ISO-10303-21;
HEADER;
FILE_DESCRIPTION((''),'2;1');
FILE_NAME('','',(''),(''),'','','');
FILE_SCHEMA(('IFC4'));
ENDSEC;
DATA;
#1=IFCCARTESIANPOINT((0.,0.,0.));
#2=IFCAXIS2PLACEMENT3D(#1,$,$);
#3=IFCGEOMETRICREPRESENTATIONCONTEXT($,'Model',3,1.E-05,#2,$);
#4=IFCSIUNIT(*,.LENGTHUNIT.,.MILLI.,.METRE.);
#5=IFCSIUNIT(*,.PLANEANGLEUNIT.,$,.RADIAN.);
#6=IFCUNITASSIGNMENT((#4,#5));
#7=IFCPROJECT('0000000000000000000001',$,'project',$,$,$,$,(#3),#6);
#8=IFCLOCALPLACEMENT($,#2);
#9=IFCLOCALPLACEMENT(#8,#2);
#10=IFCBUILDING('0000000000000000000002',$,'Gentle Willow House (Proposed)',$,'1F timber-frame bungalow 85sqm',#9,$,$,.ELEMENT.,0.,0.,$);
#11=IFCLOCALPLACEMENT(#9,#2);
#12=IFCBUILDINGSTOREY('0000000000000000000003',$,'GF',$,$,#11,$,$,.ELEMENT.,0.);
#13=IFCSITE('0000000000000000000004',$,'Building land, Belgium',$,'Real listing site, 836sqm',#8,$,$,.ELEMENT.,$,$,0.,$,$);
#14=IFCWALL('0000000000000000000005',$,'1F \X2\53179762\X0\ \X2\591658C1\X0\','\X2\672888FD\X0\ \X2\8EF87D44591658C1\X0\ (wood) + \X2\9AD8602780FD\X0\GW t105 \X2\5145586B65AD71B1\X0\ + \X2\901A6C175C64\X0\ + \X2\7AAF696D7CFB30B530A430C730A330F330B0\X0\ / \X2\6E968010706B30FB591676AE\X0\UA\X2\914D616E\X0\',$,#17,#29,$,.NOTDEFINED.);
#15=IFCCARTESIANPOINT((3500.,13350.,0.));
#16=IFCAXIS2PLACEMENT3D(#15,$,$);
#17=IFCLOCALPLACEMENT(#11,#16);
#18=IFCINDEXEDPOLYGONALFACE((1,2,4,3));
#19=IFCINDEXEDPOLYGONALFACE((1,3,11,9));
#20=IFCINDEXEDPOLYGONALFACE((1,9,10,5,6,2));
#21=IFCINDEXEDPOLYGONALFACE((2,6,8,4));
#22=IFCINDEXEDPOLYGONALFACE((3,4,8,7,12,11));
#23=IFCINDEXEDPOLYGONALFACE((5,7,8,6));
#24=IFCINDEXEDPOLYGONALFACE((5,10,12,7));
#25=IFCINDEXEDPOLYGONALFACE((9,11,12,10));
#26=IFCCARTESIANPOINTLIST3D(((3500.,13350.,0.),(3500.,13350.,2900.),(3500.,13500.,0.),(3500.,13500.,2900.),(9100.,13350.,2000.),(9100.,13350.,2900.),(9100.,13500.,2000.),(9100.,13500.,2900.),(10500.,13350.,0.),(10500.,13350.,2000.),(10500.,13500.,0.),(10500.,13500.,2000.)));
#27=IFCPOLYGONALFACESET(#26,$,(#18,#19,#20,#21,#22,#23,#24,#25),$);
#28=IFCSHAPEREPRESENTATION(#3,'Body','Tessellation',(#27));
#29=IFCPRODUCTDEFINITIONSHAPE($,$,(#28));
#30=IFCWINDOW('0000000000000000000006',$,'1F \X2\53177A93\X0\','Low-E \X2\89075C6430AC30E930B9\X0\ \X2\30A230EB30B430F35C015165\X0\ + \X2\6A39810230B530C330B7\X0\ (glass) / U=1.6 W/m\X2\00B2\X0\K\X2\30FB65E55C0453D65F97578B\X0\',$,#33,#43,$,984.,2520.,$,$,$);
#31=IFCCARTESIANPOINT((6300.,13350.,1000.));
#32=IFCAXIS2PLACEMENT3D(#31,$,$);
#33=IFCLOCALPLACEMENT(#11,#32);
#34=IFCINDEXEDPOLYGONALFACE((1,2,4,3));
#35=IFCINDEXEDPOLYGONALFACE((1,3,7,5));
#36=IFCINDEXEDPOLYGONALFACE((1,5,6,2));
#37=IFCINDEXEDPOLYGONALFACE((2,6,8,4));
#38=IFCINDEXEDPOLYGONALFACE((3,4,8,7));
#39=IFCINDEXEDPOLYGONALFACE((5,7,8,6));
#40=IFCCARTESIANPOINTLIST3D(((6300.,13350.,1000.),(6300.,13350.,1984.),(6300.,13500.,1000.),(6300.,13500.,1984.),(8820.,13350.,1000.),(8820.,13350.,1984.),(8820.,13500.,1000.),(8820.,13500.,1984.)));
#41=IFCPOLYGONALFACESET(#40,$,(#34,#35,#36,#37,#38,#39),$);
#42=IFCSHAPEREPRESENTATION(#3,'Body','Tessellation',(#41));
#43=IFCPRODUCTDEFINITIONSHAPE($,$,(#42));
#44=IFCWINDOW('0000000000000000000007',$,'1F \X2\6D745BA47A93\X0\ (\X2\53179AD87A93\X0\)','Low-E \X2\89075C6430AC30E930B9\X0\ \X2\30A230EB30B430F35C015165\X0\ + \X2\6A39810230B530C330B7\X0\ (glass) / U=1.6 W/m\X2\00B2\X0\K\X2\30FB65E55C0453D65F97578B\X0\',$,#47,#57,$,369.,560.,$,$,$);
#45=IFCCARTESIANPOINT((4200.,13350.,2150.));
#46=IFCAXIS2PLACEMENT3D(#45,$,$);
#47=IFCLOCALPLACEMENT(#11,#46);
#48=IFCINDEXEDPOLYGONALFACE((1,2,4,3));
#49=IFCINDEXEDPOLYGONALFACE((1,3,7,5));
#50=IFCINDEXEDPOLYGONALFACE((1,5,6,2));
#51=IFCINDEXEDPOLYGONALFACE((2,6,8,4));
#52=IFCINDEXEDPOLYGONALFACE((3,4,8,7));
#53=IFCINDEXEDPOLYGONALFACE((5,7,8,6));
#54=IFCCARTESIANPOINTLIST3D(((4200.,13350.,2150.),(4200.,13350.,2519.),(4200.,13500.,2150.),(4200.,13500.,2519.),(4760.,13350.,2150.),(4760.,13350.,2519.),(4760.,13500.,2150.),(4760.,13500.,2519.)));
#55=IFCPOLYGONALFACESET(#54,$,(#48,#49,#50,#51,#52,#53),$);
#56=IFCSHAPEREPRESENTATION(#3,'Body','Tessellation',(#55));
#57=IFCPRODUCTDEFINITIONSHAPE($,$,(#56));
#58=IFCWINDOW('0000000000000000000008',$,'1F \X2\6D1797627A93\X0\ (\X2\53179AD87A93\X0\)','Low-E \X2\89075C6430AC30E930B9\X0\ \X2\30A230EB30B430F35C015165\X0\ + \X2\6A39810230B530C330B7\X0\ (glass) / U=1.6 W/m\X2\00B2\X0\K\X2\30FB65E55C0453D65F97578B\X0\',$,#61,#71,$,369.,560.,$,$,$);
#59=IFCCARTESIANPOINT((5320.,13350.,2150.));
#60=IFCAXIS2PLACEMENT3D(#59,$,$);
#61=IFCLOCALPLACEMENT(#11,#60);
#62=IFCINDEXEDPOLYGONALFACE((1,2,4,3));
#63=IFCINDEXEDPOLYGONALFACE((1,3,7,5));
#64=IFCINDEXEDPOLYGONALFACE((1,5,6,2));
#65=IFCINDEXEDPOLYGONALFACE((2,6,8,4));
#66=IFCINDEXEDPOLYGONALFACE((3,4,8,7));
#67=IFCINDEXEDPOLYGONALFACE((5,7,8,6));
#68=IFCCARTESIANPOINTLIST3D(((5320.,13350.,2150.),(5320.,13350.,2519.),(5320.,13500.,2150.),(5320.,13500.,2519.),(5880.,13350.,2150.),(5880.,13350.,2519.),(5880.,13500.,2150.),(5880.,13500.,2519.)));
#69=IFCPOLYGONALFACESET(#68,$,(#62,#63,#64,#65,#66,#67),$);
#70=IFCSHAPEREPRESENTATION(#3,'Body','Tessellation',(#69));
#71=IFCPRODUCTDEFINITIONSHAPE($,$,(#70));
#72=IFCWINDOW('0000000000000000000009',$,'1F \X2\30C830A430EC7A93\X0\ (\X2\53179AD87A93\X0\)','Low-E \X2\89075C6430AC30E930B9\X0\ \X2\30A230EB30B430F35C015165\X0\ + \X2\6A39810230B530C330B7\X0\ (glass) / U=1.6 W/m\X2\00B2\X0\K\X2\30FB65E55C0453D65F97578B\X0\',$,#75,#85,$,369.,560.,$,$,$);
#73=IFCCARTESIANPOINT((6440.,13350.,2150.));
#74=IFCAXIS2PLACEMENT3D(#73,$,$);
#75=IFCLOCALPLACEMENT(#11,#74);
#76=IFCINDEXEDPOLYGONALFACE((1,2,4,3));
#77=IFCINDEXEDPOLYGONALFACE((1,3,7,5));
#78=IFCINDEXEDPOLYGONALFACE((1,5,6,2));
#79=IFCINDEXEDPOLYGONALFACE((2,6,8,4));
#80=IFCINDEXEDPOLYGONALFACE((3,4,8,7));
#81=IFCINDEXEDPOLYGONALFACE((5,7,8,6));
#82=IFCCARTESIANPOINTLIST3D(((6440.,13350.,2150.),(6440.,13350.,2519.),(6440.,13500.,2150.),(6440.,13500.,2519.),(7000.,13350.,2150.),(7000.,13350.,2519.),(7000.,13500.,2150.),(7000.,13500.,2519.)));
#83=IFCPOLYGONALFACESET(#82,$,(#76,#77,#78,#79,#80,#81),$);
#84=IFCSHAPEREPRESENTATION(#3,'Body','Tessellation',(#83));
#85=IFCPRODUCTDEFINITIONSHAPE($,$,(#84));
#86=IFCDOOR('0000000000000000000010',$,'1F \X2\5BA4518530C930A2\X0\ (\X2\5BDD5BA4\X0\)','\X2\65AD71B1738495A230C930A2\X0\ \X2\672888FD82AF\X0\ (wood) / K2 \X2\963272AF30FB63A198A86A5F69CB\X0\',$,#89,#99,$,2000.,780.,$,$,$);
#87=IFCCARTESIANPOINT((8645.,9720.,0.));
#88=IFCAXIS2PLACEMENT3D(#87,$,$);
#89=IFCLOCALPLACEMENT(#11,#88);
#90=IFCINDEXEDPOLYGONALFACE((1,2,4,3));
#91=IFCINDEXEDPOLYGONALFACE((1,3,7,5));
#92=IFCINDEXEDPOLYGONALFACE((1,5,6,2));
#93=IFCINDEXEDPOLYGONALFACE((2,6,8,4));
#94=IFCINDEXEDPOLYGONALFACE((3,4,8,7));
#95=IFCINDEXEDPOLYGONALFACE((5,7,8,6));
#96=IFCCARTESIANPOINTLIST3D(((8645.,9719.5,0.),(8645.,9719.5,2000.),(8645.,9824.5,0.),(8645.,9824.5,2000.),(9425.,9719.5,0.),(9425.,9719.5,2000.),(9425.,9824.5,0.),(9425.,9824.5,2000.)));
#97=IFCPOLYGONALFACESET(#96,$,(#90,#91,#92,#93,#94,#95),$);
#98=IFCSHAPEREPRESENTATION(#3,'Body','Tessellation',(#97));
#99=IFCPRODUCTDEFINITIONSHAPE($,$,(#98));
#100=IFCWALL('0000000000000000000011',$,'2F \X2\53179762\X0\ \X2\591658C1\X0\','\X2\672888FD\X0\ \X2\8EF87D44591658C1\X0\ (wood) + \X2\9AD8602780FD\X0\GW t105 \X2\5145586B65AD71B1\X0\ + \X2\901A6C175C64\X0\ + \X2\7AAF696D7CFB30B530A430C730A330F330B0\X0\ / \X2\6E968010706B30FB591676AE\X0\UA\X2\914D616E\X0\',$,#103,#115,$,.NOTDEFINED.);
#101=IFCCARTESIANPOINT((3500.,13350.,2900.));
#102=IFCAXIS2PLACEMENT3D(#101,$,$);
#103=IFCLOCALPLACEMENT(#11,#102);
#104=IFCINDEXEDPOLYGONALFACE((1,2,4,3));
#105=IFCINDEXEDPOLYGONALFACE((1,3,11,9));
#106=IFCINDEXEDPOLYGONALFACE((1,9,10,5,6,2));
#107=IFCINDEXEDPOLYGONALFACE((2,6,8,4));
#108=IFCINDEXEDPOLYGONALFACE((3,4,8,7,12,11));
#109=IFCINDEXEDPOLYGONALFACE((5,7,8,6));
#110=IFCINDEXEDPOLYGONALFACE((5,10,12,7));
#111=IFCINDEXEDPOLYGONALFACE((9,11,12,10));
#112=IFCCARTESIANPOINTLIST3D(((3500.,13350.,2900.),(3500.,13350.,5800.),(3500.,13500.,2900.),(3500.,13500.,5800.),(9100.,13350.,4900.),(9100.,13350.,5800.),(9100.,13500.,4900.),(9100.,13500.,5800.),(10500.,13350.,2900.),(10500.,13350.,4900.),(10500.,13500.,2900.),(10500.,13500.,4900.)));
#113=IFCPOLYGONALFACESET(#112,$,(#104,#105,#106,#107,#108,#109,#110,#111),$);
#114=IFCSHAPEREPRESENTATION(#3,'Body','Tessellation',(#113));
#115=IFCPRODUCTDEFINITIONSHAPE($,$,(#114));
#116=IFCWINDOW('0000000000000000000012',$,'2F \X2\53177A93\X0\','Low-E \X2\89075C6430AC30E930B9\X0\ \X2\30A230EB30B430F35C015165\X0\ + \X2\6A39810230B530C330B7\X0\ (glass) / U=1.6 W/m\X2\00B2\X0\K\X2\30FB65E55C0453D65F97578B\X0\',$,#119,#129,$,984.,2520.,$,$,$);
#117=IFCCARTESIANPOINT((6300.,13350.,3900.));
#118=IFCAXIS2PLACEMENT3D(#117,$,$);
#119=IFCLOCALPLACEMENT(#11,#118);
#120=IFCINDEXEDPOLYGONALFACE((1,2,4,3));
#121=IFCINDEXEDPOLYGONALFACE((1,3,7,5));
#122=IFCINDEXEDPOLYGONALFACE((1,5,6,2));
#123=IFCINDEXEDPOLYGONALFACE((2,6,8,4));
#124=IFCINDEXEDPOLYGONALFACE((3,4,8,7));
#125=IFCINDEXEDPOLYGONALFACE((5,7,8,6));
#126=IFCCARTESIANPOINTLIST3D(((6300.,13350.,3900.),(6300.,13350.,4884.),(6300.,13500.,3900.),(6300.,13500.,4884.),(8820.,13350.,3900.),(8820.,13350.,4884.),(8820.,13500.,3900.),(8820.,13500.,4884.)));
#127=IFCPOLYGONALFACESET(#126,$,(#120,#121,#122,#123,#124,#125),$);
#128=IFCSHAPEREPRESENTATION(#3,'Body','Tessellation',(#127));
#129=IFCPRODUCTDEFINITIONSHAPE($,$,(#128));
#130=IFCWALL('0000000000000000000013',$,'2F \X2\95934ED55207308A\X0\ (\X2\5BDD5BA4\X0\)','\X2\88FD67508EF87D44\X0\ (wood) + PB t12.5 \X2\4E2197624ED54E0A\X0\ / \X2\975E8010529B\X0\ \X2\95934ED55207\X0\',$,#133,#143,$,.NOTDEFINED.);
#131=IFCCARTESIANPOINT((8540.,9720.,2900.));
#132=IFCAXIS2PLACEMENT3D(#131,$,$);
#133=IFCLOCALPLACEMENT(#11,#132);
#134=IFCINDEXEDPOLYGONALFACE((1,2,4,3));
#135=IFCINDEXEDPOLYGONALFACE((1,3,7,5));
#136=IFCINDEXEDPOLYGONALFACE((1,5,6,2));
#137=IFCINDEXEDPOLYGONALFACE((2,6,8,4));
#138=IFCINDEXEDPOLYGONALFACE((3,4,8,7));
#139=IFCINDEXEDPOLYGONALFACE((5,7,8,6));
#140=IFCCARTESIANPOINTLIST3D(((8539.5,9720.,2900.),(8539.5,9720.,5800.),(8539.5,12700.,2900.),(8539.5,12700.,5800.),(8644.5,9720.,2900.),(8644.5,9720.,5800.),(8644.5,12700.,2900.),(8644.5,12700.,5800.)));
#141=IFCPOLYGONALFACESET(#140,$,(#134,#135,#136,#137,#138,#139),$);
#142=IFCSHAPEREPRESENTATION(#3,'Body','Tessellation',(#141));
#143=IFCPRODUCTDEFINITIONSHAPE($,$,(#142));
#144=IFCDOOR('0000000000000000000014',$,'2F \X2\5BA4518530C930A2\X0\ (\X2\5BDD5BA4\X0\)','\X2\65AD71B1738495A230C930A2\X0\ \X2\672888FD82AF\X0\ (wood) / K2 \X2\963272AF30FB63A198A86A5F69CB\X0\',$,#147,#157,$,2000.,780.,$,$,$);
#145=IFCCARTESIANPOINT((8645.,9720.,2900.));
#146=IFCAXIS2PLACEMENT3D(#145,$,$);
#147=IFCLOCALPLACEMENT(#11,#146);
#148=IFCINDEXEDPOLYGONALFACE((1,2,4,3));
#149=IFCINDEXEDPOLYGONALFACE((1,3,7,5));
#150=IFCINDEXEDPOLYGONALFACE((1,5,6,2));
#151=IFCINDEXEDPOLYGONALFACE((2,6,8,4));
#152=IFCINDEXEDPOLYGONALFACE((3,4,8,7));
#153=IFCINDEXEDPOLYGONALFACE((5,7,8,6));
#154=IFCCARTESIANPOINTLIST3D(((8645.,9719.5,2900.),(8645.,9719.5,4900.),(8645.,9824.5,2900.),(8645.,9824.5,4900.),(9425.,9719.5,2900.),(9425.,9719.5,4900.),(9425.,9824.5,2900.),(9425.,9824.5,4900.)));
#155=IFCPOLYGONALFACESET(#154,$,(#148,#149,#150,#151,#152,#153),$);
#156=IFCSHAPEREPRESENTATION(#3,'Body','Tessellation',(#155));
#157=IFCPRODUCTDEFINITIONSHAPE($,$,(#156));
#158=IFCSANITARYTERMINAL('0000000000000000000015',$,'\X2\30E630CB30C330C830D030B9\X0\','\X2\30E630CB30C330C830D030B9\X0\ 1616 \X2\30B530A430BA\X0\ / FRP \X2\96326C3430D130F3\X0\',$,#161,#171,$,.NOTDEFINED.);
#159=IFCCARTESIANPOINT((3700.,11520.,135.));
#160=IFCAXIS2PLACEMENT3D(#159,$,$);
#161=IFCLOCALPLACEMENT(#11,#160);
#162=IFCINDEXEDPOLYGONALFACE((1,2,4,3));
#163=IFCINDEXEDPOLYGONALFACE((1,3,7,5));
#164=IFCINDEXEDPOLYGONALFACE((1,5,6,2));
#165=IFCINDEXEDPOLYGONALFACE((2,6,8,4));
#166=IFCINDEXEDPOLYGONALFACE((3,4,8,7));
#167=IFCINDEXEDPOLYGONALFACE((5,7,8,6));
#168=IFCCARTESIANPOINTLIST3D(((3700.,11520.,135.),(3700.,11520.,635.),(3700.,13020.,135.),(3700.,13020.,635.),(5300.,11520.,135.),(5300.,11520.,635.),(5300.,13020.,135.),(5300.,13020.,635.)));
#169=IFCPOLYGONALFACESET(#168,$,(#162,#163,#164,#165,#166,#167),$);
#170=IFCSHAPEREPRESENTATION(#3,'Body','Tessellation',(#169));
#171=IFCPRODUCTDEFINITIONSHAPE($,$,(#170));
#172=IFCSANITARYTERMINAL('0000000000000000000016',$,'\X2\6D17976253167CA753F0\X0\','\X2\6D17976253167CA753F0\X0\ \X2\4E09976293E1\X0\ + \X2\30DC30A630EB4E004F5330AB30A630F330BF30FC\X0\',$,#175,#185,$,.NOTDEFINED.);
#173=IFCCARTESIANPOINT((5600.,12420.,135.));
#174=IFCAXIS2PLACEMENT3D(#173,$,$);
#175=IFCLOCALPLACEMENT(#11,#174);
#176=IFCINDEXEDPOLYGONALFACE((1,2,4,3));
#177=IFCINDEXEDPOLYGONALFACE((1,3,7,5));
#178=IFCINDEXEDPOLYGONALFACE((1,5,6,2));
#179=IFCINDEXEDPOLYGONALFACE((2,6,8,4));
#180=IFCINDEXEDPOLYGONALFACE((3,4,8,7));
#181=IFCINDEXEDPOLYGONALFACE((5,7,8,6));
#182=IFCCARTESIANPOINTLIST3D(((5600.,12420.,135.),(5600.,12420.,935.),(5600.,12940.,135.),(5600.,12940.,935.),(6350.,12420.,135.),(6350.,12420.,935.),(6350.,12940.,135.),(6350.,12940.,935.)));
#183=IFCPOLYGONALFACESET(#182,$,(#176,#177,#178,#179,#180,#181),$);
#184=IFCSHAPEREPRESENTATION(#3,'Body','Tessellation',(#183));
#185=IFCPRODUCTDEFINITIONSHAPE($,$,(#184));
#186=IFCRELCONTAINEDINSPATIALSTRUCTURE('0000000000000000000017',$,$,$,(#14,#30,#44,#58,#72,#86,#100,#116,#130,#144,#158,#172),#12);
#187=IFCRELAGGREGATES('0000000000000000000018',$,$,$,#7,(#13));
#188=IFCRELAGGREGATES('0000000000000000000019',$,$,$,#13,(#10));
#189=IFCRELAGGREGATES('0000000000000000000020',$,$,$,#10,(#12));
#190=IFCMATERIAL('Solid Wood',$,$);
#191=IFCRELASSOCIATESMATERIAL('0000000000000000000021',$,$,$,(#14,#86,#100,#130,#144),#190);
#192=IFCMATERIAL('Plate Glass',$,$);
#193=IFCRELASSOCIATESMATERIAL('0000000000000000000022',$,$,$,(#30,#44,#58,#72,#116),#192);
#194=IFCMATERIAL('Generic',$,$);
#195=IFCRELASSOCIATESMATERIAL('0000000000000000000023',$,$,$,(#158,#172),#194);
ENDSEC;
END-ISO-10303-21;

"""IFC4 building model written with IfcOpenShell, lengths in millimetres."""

from ifc_helpers import new_model, si_unit, frame, frame_2d, origin, place, context, project, spatial, rectangle, extrude, material, element, fill, save


model = new_model("IFC4")

# Units and contexts
model_context = context("Model", 3, precision=1e-05, world=origin())
ifc_project = project(units=[si_unit("LENGTHUNIT", "METRE", prefix="MILLI"), si_unit("PLANEANGLEUNIT", "RADIAN")], contexts=[model_context])

# Site, building, storey
site_placement = place(None, origin())
site = spatial("IfcSite", under=ifc_project, at=site_placement, Name="Building land, Belgium", ObjectType="Real listing site, 836sqm", CompositionType="ELEMENT", RefElevation=0.0)
building_placement = place(site_placement, origin())
building = spatial("IfcBuilding", under=site, at=building_placement, Name="Gentle Willow House (Proposed)", ObjectType="1F timber-frame bungalow 85sqm", CompositionType="ELEMENT", ElevationOfRefHeight=0.0, ElevationOfTerrain=0.0)
storey_placement = place(building_placement, origin())
storey = spatial("IfcBuildingStorey", under=building, at=storey_placement, Name="GF", CompositionType="ELEMENT", Elevation=0.0)

# Wall, openings, windows
ifc_material_1 = material(Name="Solid Wood")
wall_1_placement = place(storey_placement, frame((3500.0, 13350.0, 0.0)))
wall_1 = element("IfcWall", 1, at=wall_1_placement, inside=storey, material=ifc_material_1, Name="1F 北面 外壁", Description="木製 軸組外壁 (wood) + 高性能GW t105 充填断熱 + 通気層 + 窯業系サイディング / 準耐火・外皮UA配慮", PredefinedType="NOTDEFINED", context=model_context, shape_type="SweptSolid", body=[
    extrude(rectangle(XDim=7000.0, YDim=150.0, at=frame_2d((3500.0, 75.0))), frame((3500.0, 13350.0, 0.0)), (0.0, 0.0, 1.0), 2900.0),
])
opening_1_placement = place(storey_placement, frame((6300.0, 13350.0, 1000.0)))
opening_1 = element("IfcOpeningElement", 2, at=opening_1_placement, cuts=wall_1, PredefinedType="NOTDEFINED", context=model_context, shape_type="SweptSolid", body=[
    extrude(rectangle(XDim=2520.0, YDim=150.0, at=frame_2d((1260.0, 75.0))), frame((6300.0, 13350.0, 1000.0)), (0.0, 0.0, 1.0), 984.0),
])
opening_2_placement = place(storey_placement, frame((4200.0, 13350.0, 2150.0)))
opening_2 = element("IfcOpeningElement", 3, at=opening_2_placement, cuts=wall_1, PredefinedType="NOTDEFINED", context=model_context, shape_type="SweptSolid", body=[
    extrude(rectangle(XDim=560.0, YDim=150.0, at=frame_2d((280.0, 75.0))), frame((4200.0, 13350.0, 2150.0)), (0.0, 0.0, 1.0), 369.0),
])
opening_3_placement = place(storey_placement, frame((5320.0, 13350.0, 2150.0)))
opening_3 = element("IfcOpeningElement", 4, at=opening_3_placement, cuts=wall_1, PredefinedType="NOTDEFINED", context=model_context, shape_type="SweptSolid", body=[
    extrude(rectangle(XDim=560.0, YDim=150.0, at=frame_2d((280.0, 75.0))), frame((5320.0, 13350.0, 2150.0)), (0.0, 0.0, 1.0), 369.0),
])
opening_4_placement = place(storey_placement, frame((6440.0, 13350.0, 2150.0)))
opening_4 = element("IfcOpeningElement", 5, at=opening_4_placement, cuts=wall_1, PredefinedType="NOTDEFINED", context=model_context, shape_type="SweptSolid", body=[
    extrude(rectangle(XDim=560.0, YDim=150.0, at=frame_2d((280.0, 75.0))), frame((6440.0, 13350.0, 2150.0)), (0.0, 0.0, 1.0), 369.0),
])
ifc_material_2 = material(Name="Plate Glass")
window_1_placement = place(storey_placement, frame((6300.0, 13350.0, 1000.0)))
window_1 = element("IfcWindow", 6, at=window_1_placement, inside=storey, material=ifc_material_2, Name="1F 北窓", Description="Low-E 複層ガラス アルゴン封入 + 樹脂サッシ (glass) / U=1.6 W/m²K・日射取得型", OverallHeight=984.0, OverallWidth=2520.0, context=model_context, shape_type="SweptSolid", body=[
    extrude(rectangle(XDim=2520.0, YDim=150.0, at=frame_2d((1260.0, 75.0))), frame((6300.0, 13350.0, 1000.0)), (0.0, 0.0, 1.0), 984.0),
])
fill(opening_1, window_1)
window_2_placement = place(storey_placement, frame((4200.0, 13350.0, 2150.0)))
window_2 = element("IfcWindow", 7, at=window_2_placement, inside=storey, material=ifc_material_2, Name="1F 浴室窓 (北高窓)", Description="Low-E 複層ガラス アルゴン封入 + 樹脂サッシ (glass) / U=1.6 W/m²K・日射取得型", OverallHeight=369.0, OverallWidth=560.0, context=model_context, shape_type="SweptSolid", body=[
    extrude(rectangle(XDim=560.0, YDim=150.0, at=frame_2d((280.0, 75.0))), frame((4200.0, 13350.0, 2150.0)), (0.0, 0.0, 1.0), 369.0),
])
fill(opening_2, window_2)
window_3_placement = place(storey_placement, frame((5320.0, 13350.0, 2150.0)))
window_3 = element("IfcWindow", 8, at=window_3_placement, inside=storey, material=ifc_material_2, Name="1F 洗面窓 (北高窓)", Description="Low-E 複層ガラス アルゴン封入 + 樹脂サッシ (glass) / U=1.6 W/m²K・日射取得型", OverallHeight=369.0, OverallWidth=560.0, context=model_context, shape_type="SweptSolid", body=[
    extrude(rectangle(XDim=560.0, YDim=150.0, at=frame_2d((280.0, 75.0))), frame((5320.0, 13350.0, 2150.0)), (0.0, 0.0, 1.0), 369.0),
])
fill(opening_3, window_3)
window_4_placement = place(storey_placement, frame((6440.0, 13350.0, 2150.0)))
window_4 = element("IfcWindow", 9, at=window_4_placement, inside=storey, material=ifc_material_2, Name="1F トイレ窓 (北高窓)", Description="Low-E 複層ガラス アルゴン封入 + 樹脂サッシ (glass) / U=1.6 W/m²K・日射取得型", OverallHeight=369.0, OverallWidth=560.0, context=model_context, shape_type="SweptSolid", body=[
    extrude(rectangle(XDim=560.0, YDim=150.0, at=frame_2d((280.0, 75.0))), frame((6440.0, 13350.0, 2150.0)), (0.0, 0.0, 1.0), 369.0),
])
fill(opening_4, window_4)

# Door
door_1_placement = place(storey_placement, frame((8645.0, 9720.0, 0.0)))
element("IfcDoor", 10, at=door_1_placement, inside=storey, material=ifc_material_1, Name="1F 室内ドア (寝室)", Description="断熱玄関ドア 木製芯 (wood) / K2 防犯・採風機構", OverallHeight=2000.0, OverallWidth=780.0, context=model_context, shape_type="SweptSolid", body=[
    extrude(rectangle(XDim=780.0, YDim=105.0, at=frame_2d((390.0, 52.0))), frame((8645.0, 9720.0, 0.0)), (0.0, 0.0, 1.0), 2000.0),
])

# Wall, opening, window
wall_2_placement = place(storey_placement, frame((3500.0, 13350.0, 2900.0)))
wall_2 = element("IfcWall", 11, at=wall_2_placement, inside=storey, material=ifc_material_1, Name="2F 北面 外壁", Description="木製 軸組外壁 (wood) + 高性能GW t105 充填断熱 + 通気層 + 窯業系サイディング / 準耐火・外皮UA配慮", PredefinedType="NOTDEFINED", context=model_context, shape_type="SweptSolid", body=[
    extrude(rectangle(XDim=7000.0, YDim=150.0, at=frame_2d((3500.0, 75.0))), frame((3500.0, 13350.0, 2900.0)), (0.0, 0.0, 1.0), 2900.0),
])
opening_5_placement = place(storey_placement, frame((6300.0, 13350.0, 3900.0)))
opening_5 = element("IfcOpeningElement", 12, at=opening_5_placement, cuts=wall_2, PredefinedType="NOTDEFINED", context=model_context, shape_type="SweptSolid", body=[
    extrude(rectangle(XDim=2520.0, YDim=150.0, at=frame_2d((1260.0, 75.0))), frame((6300.0, 13350.0, 3900.0)), (0.0, 0.0, 1.0), 984.0),
])
window_5_placement = place(storey_placement, frame((6300.0, 13350.0, 3900.0)))
window_5 = element("IfcWindow", 13, at=window_5_placement, inside=storey, material=ifc_material_2, Name="2F 北窓", Description="Low-E 複層ガラス アルゴン封入 + 樹脂サッシ (glass) / U=1.6 W/m²K・日射取得型", OverallHeight=984.0, OverallWidth=2520.0, context=model_context, shape_type="SweptSolid", body=[
    extrude(rectangle(XDim=2520.0, YDim=150.0, at=frame_2d((1260.0, 75.0))), frame((6300.0, 13350.0, 3900.0)), (0.0, 0.0, 1.0), 984.0),
])
fill(opening_5, window_5)

# Wall
wall_3_placement = place(storey_placement, frame((8540.0, 9720.0, 2900.0)))
element("IfcWall", 14, at=wall_3_placement, inside=storey, material=ifc_material_1, Name="2F 間仕切り (寝室)", Description="製材軸組 (wood) + PB t12.5 両面仕上 / 非耐力 間仕切", PredefinedType="NOTDEFINED", context=model_context, shape_type="SweptSolid", body=[
    extrude(rectangle(XDim=105.0, YDim=2980.0, at=frame_2d((52.0, 1490.0))), frame((8540.0, 9720.0, 2900.0)), (0.0, 0.0, 1.0), 2900.0),
])

# Door
door_2_placement = place(storey_placement, frame((8645.0, 9720.0, 2900.0)))
element("IfcDoor", 15, at=door_2_placement, inside=storey, material=ifc_material_1, Name="2F 室内ドア (寝室)", Description="断熱玄関ドア 木製芯 (wood) / K2 防犯・採風機構", OverallHeight=2000.0, OverallWidth=780.0, context=model_context, shape_type="SweptSolid", body=[
    extrude(rectangle(XDim=780.0, YDim=105.0, at=frame_2d((390.0, 52.0))), frame((8645.0, 9720.0, 2900.0)), (0.0, 0.0, 1.0), 2000.0),
])

# Sanitary terminals
ifc_material_3 = material(Name="Generic")
sanitary_terminal_1_placement = place(storey_placement, frame((3700.0, 11520.0, 135.0)))
element("IfcSanitaryTerminal", 16, at=sanitary_terminal_1_placement, inside=storey, material=ifc_material_3, Name="ユニットバス", Description="ユニットバス 1616 サイズ / FRP 防水パン", PredefinedType="NOTDEFINED", context=model_context, shape_type="SweptSolid", body=[
    extrude(rectangle(XDim=1600.0, YDim=1500.0, at=frame_2d((800.0, 750.0))), frame((3700.0, 11520.0, 135.0)), (0.0, 0.0, 1.0), 500.0),
])
sanitary_terminal_2_placement = place(storey_placement, frame((5600.0, 12420.0, 135.0)))
element("IfcSanitaryTerminal", 17, at=sanitary_terminal_2_placement, inside=storey, material=ifc_material_3, Name="洗面化粧台", Description="洗面化粧台 三面鏡 + ボウル一体カウンター", PredefinedType="NOTDEFINED", context=model_context, shape_type="SweptSolid", body=[
    extrude(rectangle(XDim=750.0, YDim=520.0, at=frame_2d((375.0, 260.0))), frame((5600.0, 12420.0, 135.0)), (0.0, 0.0, 1.0), 800.0),
])

save(model, "model.ifc")
